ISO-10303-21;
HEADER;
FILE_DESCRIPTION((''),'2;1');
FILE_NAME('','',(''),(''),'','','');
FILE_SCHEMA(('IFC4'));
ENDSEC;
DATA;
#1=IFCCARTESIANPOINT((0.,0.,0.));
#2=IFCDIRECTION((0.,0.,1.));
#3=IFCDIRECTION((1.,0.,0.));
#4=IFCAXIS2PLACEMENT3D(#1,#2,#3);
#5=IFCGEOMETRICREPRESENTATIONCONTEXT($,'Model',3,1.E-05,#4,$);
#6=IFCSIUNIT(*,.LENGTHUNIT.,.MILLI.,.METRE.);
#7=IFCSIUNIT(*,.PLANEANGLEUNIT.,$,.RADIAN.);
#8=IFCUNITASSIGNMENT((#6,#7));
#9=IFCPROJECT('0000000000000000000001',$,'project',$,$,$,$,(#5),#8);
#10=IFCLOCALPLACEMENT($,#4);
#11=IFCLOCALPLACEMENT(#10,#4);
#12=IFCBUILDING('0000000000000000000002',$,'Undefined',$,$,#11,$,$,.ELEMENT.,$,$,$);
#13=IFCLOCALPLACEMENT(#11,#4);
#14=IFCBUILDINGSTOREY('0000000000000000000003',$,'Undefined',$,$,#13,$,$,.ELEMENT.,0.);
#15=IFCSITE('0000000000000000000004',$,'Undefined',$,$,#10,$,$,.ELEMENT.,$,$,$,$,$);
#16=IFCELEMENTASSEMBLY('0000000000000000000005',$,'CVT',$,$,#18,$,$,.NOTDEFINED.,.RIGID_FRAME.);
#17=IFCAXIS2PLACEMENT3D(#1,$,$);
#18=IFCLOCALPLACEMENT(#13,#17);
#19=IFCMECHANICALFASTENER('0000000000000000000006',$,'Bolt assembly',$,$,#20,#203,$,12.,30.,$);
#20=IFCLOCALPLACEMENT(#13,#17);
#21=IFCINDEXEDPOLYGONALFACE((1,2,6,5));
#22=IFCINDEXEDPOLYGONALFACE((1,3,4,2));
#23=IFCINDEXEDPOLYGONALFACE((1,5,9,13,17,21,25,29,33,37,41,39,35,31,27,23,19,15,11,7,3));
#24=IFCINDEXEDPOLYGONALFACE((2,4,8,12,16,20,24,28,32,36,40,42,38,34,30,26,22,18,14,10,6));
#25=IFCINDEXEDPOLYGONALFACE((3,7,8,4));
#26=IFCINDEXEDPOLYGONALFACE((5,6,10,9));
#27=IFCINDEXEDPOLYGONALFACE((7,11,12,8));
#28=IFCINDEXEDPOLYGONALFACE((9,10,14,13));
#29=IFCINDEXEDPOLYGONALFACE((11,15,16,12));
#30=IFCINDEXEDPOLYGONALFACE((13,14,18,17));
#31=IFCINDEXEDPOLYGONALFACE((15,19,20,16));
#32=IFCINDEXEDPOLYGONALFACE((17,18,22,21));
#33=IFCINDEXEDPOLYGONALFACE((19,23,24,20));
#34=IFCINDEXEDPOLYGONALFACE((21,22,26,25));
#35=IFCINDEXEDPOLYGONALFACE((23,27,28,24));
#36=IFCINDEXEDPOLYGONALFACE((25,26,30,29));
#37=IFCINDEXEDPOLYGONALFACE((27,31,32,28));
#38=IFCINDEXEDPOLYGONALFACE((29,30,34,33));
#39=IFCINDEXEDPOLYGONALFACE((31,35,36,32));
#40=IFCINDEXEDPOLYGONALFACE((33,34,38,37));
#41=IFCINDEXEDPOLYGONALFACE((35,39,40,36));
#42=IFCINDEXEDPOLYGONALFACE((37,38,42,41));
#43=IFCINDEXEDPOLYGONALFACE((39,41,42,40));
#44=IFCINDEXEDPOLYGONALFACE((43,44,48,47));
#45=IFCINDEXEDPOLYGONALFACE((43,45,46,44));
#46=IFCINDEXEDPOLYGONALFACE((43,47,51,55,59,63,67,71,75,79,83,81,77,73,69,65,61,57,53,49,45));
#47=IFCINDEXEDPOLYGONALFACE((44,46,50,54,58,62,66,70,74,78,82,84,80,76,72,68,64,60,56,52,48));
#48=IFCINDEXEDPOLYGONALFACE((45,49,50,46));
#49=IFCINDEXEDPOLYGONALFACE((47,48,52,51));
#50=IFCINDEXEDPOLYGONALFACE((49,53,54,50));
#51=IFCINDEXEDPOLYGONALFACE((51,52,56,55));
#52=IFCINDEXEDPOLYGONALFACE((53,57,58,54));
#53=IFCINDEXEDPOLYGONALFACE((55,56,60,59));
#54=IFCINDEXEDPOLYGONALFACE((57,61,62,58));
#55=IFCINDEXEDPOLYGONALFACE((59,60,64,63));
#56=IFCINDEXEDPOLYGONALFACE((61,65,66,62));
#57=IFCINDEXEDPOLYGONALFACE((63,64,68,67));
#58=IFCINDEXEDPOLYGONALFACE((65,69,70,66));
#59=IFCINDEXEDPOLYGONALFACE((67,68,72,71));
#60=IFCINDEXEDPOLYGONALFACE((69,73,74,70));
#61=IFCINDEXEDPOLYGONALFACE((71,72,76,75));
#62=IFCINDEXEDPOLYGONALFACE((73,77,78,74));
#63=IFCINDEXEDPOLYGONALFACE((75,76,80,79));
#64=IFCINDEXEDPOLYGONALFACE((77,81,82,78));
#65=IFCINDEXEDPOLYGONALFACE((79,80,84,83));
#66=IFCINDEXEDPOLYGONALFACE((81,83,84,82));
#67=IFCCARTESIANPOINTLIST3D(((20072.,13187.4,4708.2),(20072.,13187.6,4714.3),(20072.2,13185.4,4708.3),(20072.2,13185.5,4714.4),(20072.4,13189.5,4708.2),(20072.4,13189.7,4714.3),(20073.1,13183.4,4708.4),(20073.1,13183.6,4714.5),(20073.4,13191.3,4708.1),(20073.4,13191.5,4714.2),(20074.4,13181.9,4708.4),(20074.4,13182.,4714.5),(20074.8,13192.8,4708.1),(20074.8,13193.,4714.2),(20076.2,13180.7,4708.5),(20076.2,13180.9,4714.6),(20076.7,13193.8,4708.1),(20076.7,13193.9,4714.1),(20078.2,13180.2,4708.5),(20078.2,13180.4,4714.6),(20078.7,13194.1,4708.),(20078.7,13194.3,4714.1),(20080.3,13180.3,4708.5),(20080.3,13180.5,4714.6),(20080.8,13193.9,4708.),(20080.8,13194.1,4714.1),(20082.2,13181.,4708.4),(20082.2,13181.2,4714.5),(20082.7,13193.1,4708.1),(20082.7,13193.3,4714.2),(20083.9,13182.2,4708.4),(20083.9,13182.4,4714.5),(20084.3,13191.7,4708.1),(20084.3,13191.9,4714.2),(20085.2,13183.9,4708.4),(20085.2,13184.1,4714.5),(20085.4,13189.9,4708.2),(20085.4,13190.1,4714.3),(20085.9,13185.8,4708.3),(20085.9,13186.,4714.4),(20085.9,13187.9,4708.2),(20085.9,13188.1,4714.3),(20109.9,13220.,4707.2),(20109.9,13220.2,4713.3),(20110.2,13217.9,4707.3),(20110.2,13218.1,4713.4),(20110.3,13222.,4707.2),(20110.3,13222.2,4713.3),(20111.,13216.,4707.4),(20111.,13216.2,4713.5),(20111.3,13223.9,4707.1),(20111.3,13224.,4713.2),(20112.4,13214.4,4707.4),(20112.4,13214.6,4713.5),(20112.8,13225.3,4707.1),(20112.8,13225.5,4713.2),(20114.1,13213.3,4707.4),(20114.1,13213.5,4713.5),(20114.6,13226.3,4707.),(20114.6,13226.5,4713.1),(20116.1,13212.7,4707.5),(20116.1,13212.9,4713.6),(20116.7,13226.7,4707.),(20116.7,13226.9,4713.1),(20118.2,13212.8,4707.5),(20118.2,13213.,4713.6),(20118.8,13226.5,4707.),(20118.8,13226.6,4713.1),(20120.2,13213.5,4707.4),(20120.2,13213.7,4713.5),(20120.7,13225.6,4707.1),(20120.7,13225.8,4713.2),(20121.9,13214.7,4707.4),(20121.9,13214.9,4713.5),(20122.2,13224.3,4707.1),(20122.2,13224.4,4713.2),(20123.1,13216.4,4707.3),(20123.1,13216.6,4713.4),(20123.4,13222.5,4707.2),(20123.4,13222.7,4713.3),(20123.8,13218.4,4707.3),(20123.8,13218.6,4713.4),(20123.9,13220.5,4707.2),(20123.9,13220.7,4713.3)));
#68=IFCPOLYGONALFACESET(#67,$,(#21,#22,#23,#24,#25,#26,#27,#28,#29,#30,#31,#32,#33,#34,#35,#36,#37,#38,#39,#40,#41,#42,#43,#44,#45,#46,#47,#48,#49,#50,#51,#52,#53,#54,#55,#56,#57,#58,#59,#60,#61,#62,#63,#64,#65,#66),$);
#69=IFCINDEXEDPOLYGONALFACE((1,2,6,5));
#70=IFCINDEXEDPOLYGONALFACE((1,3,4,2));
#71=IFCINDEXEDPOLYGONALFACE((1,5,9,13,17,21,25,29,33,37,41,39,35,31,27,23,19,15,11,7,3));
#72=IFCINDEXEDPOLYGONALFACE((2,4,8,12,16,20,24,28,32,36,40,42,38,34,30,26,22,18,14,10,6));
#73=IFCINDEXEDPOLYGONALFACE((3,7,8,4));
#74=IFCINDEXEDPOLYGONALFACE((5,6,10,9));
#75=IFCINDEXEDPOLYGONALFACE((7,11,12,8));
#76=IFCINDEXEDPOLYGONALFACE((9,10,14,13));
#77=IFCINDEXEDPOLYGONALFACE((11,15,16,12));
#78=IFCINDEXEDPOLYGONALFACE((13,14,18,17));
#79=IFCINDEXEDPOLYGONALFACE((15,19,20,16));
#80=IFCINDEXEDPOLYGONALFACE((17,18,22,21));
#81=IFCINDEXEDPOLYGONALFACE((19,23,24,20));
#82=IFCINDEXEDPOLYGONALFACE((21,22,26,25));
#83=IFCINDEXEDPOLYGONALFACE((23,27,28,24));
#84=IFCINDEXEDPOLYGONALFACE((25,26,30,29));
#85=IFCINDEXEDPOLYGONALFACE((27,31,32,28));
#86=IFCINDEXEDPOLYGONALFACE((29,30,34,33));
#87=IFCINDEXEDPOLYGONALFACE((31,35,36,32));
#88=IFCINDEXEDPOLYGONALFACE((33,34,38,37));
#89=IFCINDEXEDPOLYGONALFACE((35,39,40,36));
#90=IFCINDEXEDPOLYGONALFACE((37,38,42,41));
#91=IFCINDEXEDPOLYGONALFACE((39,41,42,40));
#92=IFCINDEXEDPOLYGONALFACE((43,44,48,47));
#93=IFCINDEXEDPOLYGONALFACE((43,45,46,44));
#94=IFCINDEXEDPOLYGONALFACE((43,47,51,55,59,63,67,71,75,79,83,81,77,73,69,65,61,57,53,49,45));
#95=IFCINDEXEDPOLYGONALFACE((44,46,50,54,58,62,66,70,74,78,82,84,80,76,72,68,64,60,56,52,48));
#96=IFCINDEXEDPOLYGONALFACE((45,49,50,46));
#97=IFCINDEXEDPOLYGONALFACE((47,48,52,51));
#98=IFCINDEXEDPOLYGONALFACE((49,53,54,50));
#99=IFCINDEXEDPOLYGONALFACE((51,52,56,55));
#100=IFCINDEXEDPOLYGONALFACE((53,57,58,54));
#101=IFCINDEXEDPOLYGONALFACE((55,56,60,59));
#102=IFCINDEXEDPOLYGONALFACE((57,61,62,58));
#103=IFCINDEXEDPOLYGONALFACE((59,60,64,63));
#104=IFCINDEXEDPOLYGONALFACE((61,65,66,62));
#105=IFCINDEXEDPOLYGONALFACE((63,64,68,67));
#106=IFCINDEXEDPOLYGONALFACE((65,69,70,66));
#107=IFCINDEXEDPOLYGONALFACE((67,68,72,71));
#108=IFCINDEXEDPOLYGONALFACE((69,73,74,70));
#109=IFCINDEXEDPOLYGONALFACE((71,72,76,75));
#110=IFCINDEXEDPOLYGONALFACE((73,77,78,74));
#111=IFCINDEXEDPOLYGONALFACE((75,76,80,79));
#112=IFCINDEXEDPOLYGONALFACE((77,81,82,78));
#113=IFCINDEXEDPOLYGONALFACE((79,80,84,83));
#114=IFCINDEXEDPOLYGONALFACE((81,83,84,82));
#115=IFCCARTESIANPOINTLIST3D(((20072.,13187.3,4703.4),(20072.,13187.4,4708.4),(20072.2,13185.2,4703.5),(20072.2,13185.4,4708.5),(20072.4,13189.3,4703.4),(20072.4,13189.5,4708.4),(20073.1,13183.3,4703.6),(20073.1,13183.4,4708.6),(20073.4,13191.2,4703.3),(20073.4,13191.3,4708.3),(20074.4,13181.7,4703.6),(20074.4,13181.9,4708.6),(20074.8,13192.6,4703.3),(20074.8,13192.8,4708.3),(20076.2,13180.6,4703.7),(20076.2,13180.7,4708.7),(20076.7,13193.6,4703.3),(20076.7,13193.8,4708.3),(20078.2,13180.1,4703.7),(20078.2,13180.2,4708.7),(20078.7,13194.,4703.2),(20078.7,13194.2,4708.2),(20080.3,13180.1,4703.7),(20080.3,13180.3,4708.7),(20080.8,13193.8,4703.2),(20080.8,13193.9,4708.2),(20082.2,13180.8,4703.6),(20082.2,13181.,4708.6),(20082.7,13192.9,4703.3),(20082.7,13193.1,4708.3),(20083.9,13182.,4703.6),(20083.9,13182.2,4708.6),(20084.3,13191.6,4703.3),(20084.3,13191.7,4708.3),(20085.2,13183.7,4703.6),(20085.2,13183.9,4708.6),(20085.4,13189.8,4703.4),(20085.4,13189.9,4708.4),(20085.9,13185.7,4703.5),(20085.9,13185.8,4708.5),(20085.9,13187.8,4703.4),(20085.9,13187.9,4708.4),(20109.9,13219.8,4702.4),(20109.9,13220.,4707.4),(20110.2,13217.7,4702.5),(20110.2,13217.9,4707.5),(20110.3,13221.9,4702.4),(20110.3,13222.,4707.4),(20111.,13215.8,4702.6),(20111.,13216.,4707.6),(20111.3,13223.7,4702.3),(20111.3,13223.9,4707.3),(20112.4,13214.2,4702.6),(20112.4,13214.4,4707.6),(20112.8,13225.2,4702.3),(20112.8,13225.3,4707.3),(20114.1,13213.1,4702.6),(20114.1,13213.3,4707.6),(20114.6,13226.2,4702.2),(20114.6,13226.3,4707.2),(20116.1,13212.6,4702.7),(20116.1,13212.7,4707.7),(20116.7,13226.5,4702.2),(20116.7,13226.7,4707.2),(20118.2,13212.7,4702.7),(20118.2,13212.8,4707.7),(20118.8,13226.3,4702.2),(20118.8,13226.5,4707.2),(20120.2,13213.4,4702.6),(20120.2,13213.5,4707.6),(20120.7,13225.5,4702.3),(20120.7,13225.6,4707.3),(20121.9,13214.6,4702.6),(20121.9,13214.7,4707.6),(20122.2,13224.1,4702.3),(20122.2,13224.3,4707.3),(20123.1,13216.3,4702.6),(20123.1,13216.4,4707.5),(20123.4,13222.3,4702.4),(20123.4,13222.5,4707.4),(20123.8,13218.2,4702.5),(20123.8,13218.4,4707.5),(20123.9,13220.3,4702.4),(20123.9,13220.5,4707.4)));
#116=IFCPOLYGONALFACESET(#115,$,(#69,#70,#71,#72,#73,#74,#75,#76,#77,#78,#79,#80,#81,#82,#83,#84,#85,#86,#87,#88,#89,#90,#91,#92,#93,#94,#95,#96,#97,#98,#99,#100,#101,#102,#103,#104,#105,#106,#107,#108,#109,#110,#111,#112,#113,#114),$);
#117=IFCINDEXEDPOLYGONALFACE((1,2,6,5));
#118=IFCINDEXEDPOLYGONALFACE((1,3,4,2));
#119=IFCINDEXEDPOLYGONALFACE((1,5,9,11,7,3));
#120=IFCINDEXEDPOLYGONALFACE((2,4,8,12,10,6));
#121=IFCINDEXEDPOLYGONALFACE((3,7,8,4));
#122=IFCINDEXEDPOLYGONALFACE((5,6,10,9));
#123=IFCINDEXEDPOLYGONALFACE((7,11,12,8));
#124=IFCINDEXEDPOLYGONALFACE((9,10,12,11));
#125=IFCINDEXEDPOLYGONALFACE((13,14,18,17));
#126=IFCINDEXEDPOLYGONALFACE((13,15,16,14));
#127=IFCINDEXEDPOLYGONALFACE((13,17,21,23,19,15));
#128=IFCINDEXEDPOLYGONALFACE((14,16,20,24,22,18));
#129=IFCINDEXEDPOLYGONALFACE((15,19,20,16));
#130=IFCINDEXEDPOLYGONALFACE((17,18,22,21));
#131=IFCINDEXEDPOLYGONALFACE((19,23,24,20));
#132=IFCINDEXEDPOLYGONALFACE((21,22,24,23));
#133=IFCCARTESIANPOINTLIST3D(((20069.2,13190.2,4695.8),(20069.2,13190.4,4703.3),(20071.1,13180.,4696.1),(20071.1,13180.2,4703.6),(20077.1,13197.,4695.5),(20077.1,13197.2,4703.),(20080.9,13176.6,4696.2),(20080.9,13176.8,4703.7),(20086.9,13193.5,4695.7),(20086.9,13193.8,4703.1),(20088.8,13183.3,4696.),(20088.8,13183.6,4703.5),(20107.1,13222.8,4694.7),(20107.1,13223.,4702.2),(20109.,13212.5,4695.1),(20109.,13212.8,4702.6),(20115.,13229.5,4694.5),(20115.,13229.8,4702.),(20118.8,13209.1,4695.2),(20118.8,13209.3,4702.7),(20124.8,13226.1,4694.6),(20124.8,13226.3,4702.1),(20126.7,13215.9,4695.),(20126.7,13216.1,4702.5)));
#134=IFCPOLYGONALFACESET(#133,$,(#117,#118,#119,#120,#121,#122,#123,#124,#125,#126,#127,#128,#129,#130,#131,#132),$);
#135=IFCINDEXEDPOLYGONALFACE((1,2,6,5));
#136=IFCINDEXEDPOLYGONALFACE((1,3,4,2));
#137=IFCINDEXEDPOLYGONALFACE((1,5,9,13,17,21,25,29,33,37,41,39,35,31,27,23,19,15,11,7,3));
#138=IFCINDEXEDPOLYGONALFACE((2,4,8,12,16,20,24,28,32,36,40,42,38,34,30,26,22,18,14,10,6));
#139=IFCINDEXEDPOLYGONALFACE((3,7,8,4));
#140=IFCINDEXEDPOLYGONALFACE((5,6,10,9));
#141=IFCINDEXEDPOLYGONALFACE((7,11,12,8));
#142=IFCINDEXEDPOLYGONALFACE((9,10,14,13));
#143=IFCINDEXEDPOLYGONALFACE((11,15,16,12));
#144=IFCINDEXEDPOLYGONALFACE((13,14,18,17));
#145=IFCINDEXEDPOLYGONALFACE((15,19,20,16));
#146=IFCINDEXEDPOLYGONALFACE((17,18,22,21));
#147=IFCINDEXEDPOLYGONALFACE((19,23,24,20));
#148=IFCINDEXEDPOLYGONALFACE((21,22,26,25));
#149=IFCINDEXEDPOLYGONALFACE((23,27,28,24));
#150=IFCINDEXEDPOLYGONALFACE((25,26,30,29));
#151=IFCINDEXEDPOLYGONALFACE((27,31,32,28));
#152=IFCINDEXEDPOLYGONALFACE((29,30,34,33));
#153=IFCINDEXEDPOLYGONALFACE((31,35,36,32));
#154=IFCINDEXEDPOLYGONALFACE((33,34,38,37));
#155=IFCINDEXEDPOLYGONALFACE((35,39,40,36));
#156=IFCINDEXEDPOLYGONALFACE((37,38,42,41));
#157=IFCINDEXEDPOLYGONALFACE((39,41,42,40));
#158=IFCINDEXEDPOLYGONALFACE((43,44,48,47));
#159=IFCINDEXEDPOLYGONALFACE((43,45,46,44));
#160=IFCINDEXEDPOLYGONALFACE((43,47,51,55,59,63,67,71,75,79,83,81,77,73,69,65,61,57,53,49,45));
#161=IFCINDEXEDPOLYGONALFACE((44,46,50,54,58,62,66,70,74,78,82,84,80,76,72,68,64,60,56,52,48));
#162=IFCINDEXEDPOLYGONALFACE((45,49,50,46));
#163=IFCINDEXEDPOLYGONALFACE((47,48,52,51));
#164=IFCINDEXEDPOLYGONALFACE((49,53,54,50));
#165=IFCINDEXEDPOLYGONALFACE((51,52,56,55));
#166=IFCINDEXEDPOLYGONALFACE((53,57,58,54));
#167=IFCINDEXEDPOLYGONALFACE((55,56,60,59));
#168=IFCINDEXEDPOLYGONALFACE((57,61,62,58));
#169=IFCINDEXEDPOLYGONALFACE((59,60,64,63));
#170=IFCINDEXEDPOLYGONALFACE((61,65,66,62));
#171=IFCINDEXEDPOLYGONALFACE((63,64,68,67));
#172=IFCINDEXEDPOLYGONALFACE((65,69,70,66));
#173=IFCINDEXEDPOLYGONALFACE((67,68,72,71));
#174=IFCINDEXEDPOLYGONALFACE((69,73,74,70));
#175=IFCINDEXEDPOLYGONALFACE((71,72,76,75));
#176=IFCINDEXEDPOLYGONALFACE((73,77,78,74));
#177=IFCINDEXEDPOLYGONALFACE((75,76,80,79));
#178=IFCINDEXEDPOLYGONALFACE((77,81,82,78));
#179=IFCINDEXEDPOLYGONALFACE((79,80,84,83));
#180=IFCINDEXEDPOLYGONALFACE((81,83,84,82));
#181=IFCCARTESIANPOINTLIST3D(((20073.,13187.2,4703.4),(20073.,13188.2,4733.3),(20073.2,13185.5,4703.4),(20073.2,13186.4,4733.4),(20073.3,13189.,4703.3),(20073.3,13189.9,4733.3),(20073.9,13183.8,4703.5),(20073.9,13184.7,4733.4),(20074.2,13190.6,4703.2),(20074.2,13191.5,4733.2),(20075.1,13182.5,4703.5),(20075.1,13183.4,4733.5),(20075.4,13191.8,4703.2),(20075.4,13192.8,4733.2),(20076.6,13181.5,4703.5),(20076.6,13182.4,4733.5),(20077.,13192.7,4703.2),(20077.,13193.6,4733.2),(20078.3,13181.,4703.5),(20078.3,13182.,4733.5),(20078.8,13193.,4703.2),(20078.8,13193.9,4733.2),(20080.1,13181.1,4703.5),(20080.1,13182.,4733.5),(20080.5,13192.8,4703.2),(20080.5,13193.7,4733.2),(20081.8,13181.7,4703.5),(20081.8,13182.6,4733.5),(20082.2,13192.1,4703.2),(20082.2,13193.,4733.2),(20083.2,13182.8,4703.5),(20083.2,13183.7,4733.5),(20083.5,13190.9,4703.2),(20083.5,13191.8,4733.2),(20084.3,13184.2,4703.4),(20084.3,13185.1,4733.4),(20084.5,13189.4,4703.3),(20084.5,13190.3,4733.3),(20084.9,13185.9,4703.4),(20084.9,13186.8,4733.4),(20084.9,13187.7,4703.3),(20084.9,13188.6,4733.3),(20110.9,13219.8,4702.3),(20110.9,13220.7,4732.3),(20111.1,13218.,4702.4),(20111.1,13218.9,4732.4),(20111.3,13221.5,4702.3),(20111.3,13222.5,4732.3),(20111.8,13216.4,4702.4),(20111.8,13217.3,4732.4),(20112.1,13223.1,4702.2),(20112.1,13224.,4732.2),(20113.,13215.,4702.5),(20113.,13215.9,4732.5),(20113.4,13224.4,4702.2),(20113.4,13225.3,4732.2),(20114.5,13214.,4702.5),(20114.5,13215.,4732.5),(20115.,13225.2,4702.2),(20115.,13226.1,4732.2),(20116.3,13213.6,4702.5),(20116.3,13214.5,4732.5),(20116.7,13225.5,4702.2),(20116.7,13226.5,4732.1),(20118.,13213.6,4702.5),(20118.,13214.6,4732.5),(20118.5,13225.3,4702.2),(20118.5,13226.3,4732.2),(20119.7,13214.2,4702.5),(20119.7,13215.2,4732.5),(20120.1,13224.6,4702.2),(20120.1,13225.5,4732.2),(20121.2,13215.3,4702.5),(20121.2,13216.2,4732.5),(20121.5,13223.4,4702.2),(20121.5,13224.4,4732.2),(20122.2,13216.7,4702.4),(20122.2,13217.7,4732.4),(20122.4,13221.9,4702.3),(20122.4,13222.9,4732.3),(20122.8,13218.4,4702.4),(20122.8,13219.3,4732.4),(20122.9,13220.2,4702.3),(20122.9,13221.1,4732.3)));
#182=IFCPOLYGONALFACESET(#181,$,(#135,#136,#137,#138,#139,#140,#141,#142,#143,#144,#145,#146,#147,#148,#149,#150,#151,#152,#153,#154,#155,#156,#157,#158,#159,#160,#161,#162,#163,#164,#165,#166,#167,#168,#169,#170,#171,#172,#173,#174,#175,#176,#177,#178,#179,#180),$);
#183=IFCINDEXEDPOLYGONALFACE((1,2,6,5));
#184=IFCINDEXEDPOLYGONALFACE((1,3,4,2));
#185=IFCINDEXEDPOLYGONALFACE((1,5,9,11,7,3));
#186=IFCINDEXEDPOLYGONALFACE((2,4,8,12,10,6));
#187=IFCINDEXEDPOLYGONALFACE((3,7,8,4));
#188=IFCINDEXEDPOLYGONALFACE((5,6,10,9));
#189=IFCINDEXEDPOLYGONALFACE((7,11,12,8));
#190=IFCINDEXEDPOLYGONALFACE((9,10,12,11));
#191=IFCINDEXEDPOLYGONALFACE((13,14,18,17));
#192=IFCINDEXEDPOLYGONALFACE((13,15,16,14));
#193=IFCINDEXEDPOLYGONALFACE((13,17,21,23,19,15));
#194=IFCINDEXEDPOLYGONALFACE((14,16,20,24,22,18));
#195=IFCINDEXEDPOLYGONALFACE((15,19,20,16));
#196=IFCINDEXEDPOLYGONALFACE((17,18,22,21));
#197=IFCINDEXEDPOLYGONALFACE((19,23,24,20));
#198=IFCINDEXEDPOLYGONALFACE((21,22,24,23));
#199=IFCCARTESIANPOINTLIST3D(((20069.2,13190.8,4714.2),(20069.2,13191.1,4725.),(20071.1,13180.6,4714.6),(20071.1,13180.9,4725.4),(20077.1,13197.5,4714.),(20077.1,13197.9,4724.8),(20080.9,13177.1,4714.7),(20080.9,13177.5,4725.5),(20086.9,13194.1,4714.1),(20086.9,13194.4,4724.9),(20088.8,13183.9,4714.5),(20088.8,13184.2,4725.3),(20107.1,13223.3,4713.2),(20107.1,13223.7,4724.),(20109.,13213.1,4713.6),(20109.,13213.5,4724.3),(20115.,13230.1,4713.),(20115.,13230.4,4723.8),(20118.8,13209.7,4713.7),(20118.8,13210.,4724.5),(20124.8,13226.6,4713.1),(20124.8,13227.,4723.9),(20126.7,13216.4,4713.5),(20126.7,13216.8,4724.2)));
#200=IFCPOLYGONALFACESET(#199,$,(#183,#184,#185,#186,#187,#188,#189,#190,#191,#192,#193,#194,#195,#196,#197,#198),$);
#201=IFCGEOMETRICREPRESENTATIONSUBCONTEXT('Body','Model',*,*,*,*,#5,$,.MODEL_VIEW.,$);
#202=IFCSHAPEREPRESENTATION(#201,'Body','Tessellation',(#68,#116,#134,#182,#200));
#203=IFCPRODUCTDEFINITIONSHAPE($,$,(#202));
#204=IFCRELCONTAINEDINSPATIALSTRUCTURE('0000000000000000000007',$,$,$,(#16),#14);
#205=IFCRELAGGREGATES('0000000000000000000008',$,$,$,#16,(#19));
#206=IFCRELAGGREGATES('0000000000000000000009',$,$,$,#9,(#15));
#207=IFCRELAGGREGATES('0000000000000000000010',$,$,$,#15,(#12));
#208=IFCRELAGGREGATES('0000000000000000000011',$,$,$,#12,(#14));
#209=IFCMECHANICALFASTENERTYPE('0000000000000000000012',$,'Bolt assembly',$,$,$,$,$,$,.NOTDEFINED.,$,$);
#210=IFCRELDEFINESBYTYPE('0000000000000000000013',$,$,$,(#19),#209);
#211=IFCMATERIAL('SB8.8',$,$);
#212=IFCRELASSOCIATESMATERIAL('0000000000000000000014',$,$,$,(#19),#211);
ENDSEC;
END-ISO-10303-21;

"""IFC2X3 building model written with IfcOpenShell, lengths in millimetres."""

from ifc_helpers import new_model, si_unit, frame, origin_with_axes, origin_2d_with_axis, place, context, subcontext, project, spatial, polyline, circle, outline, extrude, source, transform, mapped, material, type_object, element, aggregate, save


model = new_model("IFC2X3")

# Units and contexts
model_context = context("Model", 3, precision=1e-05, world=origin_with_axes())
body_context = subcontext(model_context, "Body", "Model", "MODEL_VIEW")
ifc_project = project(units=[si_unit("LENGTHUNIT", "METRE", prefix="MILLI"), si_unit("PLANEANGLEUNIT", "RADIAN")], contexts=[model_context])

# Site, building, storey
site_placement = place(None, origin_with_axes())
site = spatial("IfcSite", under=ifc_project, at=site_placement, Name="Undefined", CompositionType="ELEMENT")
building_placement = place(site_placement, origin_with_axes())
building = spatial("IfcBuilding", under=site, at=building_placement, Name="Undefined", CompositionType="ELEMENT")
storey_placement = place(building_placement, origin_with_axes())
storey = spatial("IfcBuildingStorey", under=building, at=storey_placement, Name="Undefined", CompositionType="ELEMENT", Elevation=0.0)

# Element assembly
assembly_1_placement = place(storey_placement, origin_with_axes())
assembly_1 = element("IfcElementAssembly", 1, at=assembly_1_placement, inside=storey, Name="CVT", AssemblyPlace="NOTDEFINED", PredefinedType="RIGID_FRAME")

# Shared definitions
ifc_material_1 = material(Name="SB8.8")
mechanical_fastener_type = type_object("IfcMechanicalFastenerType", Name="Bolt assembly")

# Mechanical fastener
shared_shape_1 = source(origin_with_axes(), body_context, "Body", "SweptSolid", [
    extrude(circle(Radius=7.0, at=origin_2d_with_axis()), frame((0.0, -6.1, 0.0), z_axis=(0.0, 1.0, 0.0), x_axis=(1.0, 0.0, 0.0)), (0.0, 0.0, 1.0), 6.1),
    extrude(circle(Radius=7.0, at=origin_2d_with_axis()), frame((0.0, -10.9, 0.0), z_axis=(0.0, 1.0, 0.0), x_axis=(1.0, 0.0, 0.0)), (0.0, 0.0, 1.0), 5.0),
    extrude(outline(polyline([(10.4, 0.0), (5.2, 9.0), (-5.2, 9.0), (-10.4, 0.0), (-5.2, -9.0), (5.2, -9.0), (10.4, 0.0)])), frame((0.0, -18.5, 0.0), z_axis=(0.0, 1.0, 0.0), x_axis=(1.0, 0.0, 0.0)), (0.0, 0.0, 1.0), 7.5),
    extrude(circle(Radius=6.0, at=origin_2d_with_axis()), frame((0.0, -11.0, 0.0), z_axis=(0.0, 1.0, 0.0), x_axis=(1.0, 0.0, 0.0)), (0.0, 0.0, 1.0), 30.0),
    extrude(outline(polyline([(10.4, 0.0), (5.2, 9.0), (-5.2, 9.0), (-10.4, 0.0), (-5.2, -9.0), (5.2, -9.0), (10.4, 0.0)])), frame((0.0, 0.0, 0.0), z_axis=(0.0, 1.0, 0.0), x_axis=(1.0, 0.0, 0.0)), (0.0, 0.0, 1.0), 10.8),
])
mechanical_fastener_1_placement = place(assembly_1_placement, frame((20079.0, 13187.3, 4714.4), z_axis=(0.651166, -0.758571, 0.023516), x_axis=(0.758935, 0.650854, -0.020177)))
mechanical_fastener_1 = element("IfcMechanicalFastener", 2, at=mechanical_fastener_1_placement, type_object=mechanical_fastener_type, material=ifc_material_1, Name="Bolt assembly", NominalDiameter=12.0, NominalLength=30.0, context=body_context, shape_type="MappedRepresentation", body=[
    mapped(shared_shape_1, transform((0.0, 0.0, 0.0))),
    mapped(shared_shape_1, transform((50.0, 0.0, 0.0))),
])
aggregate(assembly_1, [mechanical_fastener_1])

save(model, "model.ifc")
